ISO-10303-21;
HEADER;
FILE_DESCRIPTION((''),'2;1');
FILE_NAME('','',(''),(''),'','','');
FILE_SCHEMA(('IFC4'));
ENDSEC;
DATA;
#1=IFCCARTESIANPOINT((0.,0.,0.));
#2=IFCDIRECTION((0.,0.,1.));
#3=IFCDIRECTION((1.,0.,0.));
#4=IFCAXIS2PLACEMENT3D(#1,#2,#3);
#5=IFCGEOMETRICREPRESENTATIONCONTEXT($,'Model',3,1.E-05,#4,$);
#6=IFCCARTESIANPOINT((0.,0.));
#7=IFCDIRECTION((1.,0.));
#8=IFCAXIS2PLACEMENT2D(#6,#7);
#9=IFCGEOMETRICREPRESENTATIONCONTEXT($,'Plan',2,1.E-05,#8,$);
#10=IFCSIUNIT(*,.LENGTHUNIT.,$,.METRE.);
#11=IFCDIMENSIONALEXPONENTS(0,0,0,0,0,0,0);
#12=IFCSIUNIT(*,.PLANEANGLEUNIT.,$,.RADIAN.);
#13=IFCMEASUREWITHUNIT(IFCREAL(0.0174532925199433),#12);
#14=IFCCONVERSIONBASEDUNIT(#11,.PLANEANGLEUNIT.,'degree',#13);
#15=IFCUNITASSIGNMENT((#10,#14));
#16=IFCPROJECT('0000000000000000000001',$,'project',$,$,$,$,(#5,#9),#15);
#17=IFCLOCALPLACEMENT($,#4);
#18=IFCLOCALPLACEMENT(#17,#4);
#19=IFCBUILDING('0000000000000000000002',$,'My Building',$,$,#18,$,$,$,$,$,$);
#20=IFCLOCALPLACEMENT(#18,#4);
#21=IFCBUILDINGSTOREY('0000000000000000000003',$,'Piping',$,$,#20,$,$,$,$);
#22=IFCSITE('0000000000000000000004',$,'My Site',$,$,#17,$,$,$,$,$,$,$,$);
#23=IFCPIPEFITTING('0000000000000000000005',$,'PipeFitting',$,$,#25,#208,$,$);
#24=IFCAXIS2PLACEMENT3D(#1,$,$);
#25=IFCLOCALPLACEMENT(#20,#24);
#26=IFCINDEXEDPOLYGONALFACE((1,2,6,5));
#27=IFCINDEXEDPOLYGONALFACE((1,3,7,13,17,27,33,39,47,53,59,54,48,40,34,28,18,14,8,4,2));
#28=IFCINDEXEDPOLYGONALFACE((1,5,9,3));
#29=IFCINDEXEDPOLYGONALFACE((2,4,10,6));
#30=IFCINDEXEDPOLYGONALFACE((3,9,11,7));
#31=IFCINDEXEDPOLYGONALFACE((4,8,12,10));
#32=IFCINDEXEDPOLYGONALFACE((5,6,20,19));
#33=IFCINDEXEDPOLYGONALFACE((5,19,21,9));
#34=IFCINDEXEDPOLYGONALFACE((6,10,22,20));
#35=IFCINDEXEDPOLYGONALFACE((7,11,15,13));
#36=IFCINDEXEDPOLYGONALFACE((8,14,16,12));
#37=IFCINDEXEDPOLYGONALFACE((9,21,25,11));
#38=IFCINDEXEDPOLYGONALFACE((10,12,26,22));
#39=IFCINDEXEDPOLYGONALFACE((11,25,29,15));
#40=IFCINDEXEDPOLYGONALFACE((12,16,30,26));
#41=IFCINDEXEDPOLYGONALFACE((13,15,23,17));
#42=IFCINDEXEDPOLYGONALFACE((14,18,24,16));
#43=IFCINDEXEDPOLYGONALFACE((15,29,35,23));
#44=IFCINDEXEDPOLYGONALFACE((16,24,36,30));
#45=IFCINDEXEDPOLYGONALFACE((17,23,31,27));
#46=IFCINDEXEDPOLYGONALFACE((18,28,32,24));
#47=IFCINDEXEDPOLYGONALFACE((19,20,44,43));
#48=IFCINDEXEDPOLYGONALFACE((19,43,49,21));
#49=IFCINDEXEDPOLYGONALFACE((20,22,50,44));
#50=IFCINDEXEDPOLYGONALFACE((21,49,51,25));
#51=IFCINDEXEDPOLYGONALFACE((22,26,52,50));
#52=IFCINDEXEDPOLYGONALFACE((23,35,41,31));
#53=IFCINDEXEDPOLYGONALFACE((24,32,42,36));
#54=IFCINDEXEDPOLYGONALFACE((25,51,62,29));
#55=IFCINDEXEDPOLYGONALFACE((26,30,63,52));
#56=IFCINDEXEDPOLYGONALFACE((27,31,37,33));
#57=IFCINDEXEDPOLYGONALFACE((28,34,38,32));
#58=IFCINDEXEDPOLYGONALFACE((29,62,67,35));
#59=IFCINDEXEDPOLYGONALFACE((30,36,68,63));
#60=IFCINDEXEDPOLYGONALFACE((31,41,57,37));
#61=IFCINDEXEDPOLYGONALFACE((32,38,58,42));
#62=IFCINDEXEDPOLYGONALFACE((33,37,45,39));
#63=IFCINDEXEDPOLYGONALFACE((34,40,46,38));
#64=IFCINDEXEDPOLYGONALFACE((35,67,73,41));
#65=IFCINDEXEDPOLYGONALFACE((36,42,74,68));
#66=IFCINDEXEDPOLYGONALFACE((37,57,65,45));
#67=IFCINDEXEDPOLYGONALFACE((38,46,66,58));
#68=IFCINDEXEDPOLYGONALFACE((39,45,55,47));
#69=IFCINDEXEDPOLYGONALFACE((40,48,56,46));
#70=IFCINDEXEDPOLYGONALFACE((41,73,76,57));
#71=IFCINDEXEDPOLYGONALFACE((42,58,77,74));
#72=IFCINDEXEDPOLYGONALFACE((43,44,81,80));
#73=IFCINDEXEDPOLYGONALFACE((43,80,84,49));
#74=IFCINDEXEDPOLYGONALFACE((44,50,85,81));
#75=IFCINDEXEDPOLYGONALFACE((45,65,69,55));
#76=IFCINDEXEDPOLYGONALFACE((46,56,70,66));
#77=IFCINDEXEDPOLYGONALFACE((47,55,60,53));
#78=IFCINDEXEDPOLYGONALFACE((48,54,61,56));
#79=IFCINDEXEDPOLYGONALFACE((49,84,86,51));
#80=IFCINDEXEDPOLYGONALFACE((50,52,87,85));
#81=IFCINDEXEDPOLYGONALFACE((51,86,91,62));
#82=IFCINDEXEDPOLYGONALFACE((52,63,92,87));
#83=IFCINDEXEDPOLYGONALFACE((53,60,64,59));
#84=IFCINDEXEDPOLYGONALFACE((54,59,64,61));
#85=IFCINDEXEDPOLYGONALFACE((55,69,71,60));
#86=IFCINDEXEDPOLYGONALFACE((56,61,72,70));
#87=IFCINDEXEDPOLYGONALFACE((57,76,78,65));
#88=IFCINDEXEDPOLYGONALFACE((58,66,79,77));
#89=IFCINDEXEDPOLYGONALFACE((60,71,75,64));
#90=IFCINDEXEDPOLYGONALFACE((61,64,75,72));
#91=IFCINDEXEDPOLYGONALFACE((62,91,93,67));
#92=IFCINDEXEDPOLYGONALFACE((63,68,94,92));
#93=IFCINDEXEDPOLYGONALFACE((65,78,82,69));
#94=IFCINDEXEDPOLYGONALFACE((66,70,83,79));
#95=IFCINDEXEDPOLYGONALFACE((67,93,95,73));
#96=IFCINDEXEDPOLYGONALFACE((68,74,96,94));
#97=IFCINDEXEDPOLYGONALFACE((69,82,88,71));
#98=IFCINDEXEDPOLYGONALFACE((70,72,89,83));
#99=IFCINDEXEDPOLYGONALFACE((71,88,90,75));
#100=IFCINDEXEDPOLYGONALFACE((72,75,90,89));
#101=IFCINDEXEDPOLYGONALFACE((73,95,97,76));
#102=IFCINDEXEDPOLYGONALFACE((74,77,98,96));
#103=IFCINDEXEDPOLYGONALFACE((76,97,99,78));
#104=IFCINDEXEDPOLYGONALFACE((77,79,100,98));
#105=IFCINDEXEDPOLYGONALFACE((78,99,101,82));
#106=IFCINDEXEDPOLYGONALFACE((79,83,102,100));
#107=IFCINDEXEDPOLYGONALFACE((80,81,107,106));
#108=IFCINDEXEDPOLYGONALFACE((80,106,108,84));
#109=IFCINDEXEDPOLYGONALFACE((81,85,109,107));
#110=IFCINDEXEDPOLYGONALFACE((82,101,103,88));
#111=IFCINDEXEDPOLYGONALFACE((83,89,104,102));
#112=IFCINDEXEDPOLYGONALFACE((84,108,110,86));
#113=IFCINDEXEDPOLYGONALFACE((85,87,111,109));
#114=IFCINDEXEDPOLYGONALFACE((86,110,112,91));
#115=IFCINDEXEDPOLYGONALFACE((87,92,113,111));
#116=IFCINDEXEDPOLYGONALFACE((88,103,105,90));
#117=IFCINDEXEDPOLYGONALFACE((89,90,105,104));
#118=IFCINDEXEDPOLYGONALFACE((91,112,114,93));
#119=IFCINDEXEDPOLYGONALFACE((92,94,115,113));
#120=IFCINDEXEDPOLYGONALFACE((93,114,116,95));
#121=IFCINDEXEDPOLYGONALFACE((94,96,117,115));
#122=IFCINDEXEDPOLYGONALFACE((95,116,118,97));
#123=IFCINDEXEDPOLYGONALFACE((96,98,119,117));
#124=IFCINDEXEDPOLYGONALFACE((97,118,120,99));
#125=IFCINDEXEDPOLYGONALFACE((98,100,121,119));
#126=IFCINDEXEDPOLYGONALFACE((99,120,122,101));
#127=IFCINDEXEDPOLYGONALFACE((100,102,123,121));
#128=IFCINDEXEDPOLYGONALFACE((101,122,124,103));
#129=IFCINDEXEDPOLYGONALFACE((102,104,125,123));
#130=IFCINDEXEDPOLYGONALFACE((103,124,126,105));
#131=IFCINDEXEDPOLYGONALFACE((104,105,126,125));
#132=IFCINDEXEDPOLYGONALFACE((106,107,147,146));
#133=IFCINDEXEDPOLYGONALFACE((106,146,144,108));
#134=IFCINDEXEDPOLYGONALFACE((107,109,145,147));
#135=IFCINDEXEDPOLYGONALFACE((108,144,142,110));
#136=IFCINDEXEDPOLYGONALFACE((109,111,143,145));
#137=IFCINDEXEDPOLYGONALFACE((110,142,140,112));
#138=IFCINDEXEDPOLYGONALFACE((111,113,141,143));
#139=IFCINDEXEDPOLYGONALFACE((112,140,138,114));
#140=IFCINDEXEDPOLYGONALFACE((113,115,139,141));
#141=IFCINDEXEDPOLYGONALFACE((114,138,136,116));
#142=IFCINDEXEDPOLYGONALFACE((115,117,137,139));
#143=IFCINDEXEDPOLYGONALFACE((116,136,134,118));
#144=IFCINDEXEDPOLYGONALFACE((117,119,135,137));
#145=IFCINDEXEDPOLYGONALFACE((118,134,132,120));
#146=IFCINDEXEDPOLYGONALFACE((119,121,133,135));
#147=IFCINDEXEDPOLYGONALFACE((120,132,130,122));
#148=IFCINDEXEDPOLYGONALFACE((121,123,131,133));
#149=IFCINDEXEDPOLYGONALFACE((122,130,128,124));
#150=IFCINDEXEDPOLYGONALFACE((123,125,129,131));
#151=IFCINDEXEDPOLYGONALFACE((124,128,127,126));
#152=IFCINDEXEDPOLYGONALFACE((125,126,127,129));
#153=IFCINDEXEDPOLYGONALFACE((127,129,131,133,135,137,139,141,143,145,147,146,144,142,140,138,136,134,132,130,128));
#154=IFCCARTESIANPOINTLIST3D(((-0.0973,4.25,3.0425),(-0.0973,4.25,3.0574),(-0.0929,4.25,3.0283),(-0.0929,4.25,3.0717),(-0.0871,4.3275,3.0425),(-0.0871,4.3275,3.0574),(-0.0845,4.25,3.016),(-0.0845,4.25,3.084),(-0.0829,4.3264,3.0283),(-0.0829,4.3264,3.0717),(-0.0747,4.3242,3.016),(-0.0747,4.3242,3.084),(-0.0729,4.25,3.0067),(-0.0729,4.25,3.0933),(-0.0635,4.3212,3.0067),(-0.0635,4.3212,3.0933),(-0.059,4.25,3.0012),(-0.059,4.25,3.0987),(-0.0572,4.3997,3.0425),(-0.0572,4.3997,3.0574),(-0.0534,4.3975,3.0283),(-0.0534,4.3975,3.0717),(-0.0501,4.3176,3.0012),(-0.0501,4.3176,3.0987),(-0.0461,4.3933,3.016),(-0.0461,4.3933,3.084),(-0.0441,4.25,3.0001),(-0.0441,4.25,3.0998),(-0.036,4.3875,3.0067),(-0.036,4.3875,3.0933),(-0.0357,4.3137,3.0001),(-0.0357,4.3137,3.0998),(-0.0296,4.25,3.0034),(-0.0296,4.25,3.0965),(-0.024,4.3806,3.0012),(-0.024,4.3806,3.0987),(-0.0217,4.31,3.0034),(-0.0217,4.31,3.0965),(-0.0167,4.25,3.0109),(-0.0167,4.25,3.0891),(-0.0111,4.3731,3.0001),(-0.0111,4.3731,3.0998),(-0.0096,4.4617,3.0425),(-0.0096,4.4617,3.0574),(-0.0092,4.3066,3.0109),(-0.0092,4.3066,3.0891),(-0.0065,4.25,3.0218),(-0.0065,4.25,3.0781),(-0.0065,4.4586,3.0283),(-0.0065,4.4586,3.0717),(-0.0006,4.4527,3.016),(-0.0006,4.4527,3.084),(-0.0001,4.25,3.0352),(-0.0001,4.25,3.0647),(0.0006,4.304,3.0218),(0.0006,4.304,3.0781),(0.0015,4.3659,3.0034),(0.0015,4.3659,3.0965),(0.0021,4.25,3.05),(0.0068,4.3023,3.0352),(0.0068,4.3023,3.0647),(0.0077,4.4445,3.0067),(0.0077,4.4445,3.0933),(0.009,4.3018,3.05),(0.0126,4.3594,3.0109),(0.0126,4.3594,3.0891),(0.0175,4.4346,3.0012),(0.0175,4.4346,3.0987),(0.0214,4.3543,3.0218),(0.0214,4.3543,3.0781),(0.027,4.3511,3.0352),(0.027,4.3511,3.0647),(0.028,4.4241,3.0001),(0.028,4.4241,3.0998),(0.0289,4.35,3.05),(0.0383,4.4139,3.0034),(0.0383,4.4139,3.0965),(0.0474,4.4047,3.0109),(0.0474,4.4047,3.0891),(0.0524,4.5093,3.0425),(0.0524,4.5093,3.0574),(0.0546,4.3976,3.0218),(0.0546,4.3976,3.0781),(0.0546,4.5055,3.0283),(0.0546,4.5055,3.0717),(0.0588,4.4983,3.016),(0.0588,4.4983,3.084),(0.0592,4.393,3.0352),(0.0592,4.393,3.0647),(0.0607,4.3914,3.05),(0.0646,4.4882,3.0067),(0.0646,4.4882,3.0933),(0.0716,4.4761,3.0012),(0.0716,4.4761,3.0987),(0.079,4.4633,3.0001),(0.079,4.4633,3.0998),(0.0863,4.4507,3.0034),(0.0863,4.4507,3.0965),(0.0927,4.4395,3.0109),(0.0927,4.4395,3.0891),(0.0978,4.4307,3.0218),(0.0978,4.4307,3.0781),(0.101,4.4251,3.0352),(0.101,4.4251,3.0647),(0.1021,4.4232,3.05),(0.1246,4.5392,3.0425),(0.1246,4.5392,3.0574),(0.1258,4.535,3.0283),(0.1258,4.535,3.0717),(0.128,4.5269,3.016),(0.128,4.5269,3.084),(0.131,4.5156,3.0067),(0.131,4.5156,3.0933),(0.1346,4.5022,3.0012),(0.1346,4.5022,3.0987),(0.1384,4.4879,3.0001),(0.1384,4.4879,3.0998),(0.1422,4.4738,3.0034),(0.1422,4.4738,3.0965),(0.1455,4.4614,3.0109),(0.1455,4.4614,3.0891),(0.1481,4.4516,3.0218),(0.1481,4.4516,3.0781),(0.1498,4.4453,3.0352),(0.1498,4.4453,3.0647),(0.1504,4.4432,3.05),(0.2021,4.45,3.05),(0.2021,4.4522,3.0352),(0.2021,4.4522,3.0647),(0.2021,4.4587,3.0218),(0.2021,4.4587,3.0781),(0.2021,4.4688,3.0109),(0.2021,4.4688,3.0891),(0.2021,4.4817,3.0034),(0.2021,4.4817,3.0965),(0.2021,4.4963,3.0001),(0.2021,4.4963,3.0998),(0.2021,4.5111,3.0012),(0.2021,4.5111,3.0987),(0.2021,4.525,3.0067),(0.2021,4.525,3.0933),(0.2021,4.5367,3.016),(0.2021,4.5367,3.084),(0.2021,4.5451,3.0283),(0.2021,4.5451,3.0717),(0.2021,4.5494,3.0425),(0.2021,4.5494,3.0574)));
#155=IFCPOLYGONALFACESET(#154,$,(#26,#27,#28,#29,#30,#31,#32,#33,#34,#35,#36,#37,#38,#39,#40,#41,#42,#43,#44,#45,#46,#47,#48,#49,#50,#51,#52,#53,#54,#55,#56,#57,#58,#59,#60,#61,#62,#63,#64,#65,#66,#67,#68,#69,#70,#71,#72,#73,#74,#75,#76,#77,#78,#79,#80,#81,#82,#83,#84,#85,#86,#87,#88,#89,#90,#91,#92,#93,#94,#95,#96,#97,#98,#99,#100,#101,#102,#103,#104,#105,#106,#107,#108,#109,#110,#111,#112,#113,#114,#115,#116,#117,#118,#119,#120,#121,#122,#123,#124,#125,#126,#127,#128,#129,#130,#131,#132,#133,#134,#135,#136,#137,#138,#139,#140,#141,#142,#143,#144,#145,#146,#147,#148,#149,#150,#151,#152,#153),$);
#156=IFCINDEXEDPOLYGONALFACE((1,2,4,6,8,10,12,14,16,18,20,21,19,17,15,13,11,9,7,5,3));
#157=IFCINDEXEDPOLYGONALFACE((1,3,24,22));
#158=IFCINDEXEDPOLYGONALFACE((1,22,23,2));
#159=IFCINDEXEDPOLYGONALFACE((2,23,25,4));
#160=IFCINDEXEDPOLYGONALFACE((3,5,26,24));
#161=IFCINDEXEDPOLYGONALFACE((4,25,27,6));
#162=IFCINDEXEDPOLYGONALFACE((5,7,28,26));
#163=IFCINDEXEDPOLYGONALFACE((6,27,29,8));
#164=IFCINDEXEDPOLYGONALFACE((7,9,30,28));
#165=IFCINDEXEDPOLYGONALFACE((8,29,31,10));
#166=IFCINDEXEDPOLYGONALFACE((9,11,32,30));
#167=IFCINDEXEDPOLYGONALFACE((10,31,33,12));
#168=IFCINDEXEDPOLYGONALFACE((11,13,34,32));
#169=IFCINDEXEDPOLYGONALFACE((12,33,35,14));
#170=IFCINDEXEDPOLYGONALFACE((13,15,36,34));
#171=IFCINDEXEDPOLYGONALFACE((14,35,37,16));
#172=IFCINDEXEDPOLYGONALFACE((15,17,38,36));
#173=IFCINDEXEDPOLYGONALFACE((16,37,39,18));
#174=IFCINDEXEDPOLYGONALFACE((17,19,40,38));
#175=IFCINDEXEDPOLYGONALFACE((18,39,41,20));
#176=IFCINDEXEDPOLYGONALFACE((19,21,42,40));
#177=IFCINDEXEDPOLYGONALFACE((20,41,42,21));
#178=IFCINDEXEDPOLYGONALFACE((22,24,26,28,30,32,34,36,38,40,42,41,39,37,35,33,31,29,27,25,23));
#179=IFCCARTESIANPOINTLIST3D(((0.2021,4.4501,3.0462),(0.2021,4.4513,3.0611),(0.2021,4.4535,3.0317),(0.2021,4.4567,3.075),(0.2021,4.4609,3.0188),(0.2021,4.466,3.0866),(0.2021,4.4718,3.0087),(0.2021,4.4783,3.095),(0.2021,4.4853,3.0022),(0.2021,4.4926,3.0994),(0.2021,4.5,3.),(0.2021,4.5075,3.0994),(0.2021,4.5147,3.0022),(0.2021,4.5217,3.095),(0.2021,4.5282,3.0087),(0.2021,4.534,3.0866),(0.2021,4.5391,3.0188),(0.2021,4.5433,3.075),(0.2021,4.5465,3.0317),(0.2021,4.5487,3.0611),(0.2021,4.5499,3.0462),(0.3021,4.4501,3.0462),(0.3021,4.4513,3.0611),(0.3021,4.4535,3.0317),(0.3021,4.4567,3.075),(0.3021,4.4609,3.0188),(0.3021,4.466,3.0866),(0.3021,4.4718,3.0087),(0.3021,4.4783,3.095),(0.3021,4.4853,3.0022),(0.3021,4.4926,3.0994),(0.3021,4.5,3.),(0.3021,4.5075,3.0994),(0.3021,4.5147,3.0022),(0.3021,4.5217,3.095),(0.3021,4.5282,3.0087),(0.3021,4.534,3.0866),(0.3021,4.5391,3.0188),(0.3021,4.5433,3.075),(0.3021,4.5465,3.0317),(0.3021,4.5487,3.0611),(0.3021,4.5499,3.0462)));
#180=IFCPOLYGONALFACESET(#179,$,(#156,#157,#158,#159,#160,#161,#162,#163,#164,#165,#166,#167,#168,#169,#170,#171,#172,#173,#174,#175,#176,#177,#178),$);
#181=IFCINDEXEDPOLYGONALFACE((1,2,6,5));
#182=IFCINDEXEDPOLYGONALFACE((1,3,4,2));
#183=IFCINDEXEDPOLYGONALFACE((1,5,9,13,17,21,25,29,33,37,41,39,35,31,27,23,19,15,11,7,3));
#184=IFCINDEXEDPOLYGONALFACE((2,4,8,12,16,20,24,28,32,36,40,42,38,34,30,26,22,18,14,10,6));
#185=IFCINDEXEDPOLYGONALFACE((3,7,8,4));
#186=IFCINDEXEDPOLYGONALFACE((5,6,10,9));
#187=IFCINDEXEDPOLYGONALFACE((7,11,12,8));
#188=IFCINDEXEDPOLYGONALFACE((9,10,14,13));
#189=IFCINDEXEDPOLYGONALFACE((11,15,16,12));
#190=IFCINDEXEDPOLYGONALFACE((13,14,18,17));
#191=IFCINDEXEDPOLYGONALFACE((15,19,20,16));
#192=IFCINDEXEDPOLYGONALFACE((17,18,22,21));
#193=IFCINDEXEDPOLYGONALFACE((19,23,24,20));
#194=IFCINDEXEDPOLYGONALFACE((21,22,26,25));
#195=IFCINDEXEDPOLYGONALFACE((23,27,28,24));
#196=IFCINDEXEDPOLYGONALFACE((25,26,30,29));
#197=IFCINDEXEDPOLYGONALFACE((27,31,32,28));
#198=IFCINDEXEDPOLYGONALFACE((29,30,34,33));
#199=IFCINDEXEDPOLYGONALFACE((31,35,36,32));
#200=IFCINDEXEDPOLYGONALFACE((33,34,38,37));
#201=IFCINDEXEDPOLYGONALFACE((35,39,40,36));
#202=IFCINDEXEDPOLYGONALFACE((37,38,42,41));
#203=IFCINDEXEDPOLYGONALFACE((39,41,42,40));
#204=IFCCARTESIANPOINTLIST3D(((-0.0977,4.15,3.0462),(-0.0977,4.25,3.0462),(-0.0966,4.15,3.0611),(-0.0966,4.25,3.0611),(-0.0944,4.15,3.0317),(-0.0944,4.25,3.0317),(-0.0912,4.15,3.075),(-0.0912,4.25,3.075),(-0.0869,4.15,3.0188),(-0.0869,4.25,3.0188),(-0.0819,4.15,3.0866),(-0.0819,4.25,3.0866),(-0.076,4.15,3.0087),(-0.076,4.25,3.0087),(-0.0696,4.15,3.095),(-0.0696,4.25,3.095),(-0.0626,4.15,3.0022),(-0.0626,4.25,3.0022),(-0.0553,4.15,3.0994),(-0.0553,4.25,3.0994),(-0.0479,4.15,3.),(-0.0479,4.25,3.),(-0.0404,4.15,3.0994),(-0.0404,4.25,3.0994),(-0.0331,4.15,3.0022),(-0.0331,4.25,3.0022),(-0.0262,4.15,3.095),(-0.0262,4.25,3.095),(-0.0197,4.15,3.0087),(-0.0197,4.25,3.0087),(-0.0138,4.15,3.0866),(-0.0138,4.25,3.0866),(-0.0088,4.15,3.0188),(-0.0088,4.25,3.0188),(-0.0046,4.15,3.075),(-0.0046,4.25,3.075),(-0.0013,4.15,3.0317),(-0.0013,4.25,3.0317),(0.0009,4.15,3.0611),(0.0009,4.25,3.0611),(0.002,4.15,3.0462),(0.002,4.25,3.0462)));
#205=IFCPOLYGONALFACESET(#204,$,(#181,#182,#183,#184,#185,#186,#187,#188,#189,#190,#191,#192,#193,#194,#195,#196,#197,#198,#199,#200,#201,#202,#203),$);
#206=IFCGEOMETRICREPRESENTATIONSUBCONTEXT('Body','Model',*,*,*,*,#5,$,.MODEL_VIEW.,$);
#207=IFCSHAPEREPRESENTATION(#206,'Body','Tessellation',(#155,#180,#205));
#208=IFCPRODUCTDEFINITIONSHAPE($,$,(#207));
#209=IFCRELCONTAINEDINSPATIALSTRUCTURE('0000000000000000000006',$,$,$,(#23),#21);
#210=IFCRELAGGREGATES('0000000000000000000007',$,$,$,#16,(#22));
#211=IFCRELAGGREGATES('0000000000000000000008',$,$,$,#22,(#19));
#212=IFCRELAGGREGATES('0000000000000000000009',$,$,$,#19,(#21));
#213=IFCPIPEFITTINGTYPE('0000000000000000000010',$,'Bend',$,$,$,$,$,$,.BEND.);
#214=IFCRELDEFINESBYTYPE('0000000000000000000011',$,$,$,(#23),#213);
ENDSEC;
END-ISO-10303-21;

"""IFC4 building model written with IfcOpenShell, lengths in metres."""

from ifc_helpers import new_model, entity, si_unit, converted_unit, frame, origin_with_axes, origin_2d_with_axis, place, context, subcontext, project, spatial, circle, extrude, source, transform, mapped, type_object, type_shapes, element, save


model = new_model("IFC4")

# Units and contexts
model_context = context("Model", 3, precision=1e-05, world=origin_with_axes())
plan_context = context("Plan", 2, precision=1e-05, world=origin_2d_with_axis())
body_context = subcontext(model_context, "Body", "Model", "MODEL_VIEW")
ifc_project = project(units=[si_unit("LENGTHUNIT", "METRE"), converted_unit("PLANEANGLEUNIT", "degree", entity("IfcReal", 0.0174532925199433), si_unit("PLANEANGLEUNIT", "RADIAN"), dimensions=[0, 0, 0, 0, 0, 0, 0])], contexts=[model_context, plan_context])

# Site, building, storey
site_placement = place(None, origin_with_axes())
site = spatial("IfcSite", under=ifc_project, at=site_placement, Name="My Site")
building_placement = place(site_placement, origin_with_axes())
building = spatial("IfcBuilding", under=site, at=building_placement, Name="My Building")
storey_placement = place(building_placement, origin_with_axes())
storey = spatial("IfcBuildingStorey", under=building, at=storey_placement, Name="Piping")

# Pipe fitting
pipe_fitting_type_1 = type_object("IfcPipeFittingType", Name="Bend", PredefinedType="BEND")
shared_shape = source(origin_with_axes(), body_context, "Body", "SolidModel", [
    entity("IfcSweptDiskSolid", entity("IfcIndexedPolyCurve", entity("IfcCartesianPointList3D", [[0.0, 0.0, -0.1], [0.0, -0.0732, -0.2768], [0.0, -0.25, -0.35]]), [entity("IfcArcIndex", [1, 2, 3])]), 0.05),
    extrude(circle(Radius=0.05), origin_with_axes(), (0.0, 0.0, -1.0), 0.1),
    extrude(circle(Radius=0.05), frame((0.0, -0.25, -0.35), z_axis=(0.0, -1.0, 0.0), x_axis=(1.0, 0.0, 0.0)), (0.0, 0.0, 1.0), 0.1),
])
type_shapes(pipe_fitting_type_1, [shared_shape])
for number, where, z_axis, x_axis, name in (
    (1, (0.3021, 4.5, 3.05), (1.0, -0.000001, 0.000001), (0.000001, 0.0, -1.0), "PipeFitting"),
):
    element("IfcPipeFitting", number, at=place(storey_placement, frame(where, z_axis=z_axis, x_axis=x_axis)), inside=storey, type_object=pipe_fitting_type_1, Name=name, context=body_context, shape_type="MappedRepresentation", body=[
        mapped(shared_shape, transform((0.0, 0.0, 0.0), x_axis=(1.0, 0.0, 0.0), y_axis=(0.0, 1.0, 0.0), z_axis=(0.0, 0.0, 1.0), scale=1.0)),
    ])

save(model, "model.ifc")
